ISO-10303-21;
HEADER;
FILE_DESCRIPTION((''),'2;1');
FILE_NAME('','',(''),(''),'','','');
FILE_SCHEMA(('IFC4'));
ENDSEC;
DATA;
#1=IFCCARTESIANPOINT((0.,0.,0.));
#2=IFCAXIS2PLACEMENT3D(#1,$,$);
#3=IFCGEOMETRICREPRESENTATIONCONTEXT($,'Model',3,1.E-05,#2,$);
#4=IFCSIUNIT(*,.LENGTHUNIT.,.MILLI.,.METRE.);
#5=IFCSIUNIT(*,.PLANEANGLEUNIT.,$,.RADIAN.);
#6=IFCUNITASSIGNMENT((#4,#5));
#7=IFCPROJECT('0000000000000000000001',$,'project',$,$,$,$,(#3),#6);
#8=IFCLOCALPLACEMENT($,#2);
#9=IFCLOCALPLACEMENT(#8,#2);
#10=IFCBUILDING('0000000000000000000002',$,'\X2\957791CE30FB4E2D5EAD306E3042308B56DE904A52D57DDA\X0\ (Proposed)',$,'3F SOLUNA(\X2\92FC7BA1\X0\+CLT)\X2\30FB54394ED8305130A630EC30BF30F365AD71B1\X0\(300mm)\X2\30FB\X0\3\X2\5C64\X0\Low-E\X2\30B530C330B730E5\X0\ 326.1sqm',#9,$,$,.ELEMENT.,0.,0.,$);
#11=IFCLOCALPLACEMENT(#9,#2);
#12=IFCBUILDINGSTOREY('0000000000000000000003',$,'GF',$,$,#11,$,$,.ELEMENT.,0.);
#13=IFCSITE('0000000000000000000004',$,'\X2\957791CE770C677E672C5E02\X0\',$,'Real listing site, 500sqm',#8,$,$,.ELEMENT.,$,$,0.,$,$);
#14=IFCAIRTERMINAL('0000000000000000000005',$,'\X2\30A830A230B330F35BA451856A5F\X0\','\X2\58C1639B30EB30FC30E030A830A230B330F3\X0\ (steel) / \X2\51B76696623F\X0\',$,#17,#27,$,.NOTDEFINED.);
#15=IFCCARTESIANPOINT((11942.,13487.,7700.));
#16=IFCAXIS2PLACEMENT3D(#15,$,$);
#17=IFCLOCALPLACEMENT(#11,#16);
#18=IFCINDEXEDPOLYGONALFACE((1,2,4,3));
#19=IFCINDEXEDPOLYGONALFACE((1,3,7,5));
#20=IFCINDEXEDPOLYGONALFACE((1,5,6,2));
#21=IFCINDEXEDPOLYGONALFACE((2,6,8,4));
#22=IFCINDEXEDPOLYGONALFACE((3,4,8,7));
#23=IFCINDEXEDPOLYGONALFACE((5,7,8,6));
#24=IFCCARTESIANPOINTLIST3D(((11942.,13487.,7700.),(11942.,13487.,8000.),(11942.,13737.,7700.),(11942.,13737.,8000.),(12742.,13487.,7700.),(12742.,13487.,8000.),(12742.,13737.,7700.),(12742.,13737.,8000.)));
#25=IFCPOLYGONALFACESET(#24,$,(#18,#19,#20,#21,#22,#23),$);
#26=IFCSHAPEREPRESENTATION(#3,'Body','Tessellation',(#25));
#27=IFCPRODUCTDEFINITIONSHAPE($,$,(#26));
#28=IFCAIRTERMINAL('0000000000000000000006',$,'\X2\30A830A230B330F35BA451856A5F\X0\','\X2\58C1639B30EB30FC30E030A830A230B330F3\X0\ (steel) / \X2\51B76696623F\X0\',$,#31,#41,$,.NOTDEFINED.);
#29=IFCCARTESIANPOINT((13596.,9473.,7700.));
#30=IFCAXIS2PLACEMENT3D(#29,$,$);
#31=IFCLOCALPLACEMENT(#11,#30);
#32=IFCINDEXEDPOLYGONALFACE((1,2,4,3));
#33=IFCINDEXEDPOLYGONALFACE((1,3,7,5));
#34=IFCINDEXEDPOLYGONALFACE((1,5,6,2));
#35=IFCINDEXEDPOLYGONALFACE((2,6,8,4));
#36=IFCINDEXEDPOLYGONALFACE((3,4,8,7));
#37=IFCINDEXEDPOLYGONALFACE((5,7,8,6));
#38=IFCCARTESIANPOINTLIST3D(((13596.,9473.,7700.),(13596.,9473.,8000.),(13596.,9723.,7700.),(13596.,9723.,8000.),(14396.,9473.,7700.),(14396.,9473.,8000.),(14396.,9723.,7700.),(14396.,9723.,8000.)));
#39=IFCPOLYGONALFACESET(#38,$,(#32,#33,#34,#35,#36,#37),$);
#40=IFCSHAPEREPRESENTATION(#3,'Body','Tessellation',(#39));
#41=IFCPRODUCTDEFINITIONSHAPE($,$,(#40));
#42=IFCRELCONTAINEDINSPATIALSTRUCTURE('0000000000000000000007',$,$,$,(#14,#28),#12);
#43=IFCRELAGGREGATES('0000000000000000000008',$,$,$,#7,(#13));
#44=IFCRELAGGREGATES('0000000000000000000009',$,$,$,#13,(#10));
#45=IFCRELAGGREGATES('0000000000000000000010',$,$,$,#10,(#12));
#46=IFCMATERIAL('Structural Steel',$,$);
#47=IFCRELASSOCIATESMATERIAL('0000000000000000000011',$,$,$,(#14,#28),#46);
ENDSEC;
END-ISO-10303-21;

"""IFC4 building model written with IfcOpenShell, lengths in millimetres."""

from ifc_helpers import new_model, si_unit, frame, frame_2d, origin, place, context, project, spatial, rectangle, extrude, material, element, save


model = new_model("IFC4")

# Units and contexts
model_context = context("Model", 3, precision=1e-05, world=origin())
ifc_project = project(units=[si_unit("LENGTHUNIT", "METRE", prefix="MILLI"), si_unit("PLANEANGLEUNIT", "RADIAN")], contexts=[model_context])

# Site, building, storey
site_placement = place(None, origin())
site = spatial("IfcSite", under=ifc_project, at=site_placement, Name="長野県松本市", ObjectType="Real listing site, 500sqm", CompositionType="ELEMENT", RefElevation=0.0)
building_placement = place(site_placement, origin())
building = spatial("IfcBuilding", under=site, at=building_placement, Name="長野・中庭のある回遊動線 (Proposed)", ObjectType="3F SOLUNA(鋼管+CLT)・吹付けウレタン断熱(300mm)・3層Low-Eサッシュ 326.1sqm", CompositionType="ELEMENT", ElevationOfRefHeight=0.0, ElevationOfTerrain=0.0)
storey_placement = place(building_placement, origin())
storey = spatial("IfcBuildingStorey", under=building, at=storey_placement, Name="GF", CompositionType="ELEMENT", Elevation=0.0)

# Air terminals
ifc_material_1 = material(Name="Structural Steel")
air_terminal_1_placement = place(storey_placement, frame((11942.0, 13487.0, 7700.0)))
element("IfcAirTerminal", 1, at=air_terminal_1_placement, inside=storey, material=ifc_material_1, Name="エアコン室内機", Description="壁掛ルームエアコン (steel) / 冷暖房", PredefinedType="NOTDEFINED", context=model_context, shape_type="SweptSolid", body=[
    extrude(rectangle(XDim=800.0, YDim=250.0, at=frame_2d((400.0, 125.0))), frame((11942.0, 13487.0, 7700.0)), (0.0, 0.0, 1.0), 300.0),
])
air_terminal_2_placement = place(storey_placement, frame((13596.0, 9473.0, 7700.0)))
element("IfcAirTerminal", 2, at=air_terminal_2_placement, inside=storey, material=ifc_material_1, Name="エアコン室内機", Description="壁掛ルームエアコン (steel) / 冷暖房", PredefinedType="NOTDEFINED", context=model_context, shape_type="SweptSolid", body=[
    extrude(rectangle(XDim=800.0, YDim=250.0, at=frame_2d((400.0, 125.0))), frame((13596.0, 9473.0, 7700.0)), (0.0, 0.0, 1.0), 300.0),
])

save(model, "model.ifc")
